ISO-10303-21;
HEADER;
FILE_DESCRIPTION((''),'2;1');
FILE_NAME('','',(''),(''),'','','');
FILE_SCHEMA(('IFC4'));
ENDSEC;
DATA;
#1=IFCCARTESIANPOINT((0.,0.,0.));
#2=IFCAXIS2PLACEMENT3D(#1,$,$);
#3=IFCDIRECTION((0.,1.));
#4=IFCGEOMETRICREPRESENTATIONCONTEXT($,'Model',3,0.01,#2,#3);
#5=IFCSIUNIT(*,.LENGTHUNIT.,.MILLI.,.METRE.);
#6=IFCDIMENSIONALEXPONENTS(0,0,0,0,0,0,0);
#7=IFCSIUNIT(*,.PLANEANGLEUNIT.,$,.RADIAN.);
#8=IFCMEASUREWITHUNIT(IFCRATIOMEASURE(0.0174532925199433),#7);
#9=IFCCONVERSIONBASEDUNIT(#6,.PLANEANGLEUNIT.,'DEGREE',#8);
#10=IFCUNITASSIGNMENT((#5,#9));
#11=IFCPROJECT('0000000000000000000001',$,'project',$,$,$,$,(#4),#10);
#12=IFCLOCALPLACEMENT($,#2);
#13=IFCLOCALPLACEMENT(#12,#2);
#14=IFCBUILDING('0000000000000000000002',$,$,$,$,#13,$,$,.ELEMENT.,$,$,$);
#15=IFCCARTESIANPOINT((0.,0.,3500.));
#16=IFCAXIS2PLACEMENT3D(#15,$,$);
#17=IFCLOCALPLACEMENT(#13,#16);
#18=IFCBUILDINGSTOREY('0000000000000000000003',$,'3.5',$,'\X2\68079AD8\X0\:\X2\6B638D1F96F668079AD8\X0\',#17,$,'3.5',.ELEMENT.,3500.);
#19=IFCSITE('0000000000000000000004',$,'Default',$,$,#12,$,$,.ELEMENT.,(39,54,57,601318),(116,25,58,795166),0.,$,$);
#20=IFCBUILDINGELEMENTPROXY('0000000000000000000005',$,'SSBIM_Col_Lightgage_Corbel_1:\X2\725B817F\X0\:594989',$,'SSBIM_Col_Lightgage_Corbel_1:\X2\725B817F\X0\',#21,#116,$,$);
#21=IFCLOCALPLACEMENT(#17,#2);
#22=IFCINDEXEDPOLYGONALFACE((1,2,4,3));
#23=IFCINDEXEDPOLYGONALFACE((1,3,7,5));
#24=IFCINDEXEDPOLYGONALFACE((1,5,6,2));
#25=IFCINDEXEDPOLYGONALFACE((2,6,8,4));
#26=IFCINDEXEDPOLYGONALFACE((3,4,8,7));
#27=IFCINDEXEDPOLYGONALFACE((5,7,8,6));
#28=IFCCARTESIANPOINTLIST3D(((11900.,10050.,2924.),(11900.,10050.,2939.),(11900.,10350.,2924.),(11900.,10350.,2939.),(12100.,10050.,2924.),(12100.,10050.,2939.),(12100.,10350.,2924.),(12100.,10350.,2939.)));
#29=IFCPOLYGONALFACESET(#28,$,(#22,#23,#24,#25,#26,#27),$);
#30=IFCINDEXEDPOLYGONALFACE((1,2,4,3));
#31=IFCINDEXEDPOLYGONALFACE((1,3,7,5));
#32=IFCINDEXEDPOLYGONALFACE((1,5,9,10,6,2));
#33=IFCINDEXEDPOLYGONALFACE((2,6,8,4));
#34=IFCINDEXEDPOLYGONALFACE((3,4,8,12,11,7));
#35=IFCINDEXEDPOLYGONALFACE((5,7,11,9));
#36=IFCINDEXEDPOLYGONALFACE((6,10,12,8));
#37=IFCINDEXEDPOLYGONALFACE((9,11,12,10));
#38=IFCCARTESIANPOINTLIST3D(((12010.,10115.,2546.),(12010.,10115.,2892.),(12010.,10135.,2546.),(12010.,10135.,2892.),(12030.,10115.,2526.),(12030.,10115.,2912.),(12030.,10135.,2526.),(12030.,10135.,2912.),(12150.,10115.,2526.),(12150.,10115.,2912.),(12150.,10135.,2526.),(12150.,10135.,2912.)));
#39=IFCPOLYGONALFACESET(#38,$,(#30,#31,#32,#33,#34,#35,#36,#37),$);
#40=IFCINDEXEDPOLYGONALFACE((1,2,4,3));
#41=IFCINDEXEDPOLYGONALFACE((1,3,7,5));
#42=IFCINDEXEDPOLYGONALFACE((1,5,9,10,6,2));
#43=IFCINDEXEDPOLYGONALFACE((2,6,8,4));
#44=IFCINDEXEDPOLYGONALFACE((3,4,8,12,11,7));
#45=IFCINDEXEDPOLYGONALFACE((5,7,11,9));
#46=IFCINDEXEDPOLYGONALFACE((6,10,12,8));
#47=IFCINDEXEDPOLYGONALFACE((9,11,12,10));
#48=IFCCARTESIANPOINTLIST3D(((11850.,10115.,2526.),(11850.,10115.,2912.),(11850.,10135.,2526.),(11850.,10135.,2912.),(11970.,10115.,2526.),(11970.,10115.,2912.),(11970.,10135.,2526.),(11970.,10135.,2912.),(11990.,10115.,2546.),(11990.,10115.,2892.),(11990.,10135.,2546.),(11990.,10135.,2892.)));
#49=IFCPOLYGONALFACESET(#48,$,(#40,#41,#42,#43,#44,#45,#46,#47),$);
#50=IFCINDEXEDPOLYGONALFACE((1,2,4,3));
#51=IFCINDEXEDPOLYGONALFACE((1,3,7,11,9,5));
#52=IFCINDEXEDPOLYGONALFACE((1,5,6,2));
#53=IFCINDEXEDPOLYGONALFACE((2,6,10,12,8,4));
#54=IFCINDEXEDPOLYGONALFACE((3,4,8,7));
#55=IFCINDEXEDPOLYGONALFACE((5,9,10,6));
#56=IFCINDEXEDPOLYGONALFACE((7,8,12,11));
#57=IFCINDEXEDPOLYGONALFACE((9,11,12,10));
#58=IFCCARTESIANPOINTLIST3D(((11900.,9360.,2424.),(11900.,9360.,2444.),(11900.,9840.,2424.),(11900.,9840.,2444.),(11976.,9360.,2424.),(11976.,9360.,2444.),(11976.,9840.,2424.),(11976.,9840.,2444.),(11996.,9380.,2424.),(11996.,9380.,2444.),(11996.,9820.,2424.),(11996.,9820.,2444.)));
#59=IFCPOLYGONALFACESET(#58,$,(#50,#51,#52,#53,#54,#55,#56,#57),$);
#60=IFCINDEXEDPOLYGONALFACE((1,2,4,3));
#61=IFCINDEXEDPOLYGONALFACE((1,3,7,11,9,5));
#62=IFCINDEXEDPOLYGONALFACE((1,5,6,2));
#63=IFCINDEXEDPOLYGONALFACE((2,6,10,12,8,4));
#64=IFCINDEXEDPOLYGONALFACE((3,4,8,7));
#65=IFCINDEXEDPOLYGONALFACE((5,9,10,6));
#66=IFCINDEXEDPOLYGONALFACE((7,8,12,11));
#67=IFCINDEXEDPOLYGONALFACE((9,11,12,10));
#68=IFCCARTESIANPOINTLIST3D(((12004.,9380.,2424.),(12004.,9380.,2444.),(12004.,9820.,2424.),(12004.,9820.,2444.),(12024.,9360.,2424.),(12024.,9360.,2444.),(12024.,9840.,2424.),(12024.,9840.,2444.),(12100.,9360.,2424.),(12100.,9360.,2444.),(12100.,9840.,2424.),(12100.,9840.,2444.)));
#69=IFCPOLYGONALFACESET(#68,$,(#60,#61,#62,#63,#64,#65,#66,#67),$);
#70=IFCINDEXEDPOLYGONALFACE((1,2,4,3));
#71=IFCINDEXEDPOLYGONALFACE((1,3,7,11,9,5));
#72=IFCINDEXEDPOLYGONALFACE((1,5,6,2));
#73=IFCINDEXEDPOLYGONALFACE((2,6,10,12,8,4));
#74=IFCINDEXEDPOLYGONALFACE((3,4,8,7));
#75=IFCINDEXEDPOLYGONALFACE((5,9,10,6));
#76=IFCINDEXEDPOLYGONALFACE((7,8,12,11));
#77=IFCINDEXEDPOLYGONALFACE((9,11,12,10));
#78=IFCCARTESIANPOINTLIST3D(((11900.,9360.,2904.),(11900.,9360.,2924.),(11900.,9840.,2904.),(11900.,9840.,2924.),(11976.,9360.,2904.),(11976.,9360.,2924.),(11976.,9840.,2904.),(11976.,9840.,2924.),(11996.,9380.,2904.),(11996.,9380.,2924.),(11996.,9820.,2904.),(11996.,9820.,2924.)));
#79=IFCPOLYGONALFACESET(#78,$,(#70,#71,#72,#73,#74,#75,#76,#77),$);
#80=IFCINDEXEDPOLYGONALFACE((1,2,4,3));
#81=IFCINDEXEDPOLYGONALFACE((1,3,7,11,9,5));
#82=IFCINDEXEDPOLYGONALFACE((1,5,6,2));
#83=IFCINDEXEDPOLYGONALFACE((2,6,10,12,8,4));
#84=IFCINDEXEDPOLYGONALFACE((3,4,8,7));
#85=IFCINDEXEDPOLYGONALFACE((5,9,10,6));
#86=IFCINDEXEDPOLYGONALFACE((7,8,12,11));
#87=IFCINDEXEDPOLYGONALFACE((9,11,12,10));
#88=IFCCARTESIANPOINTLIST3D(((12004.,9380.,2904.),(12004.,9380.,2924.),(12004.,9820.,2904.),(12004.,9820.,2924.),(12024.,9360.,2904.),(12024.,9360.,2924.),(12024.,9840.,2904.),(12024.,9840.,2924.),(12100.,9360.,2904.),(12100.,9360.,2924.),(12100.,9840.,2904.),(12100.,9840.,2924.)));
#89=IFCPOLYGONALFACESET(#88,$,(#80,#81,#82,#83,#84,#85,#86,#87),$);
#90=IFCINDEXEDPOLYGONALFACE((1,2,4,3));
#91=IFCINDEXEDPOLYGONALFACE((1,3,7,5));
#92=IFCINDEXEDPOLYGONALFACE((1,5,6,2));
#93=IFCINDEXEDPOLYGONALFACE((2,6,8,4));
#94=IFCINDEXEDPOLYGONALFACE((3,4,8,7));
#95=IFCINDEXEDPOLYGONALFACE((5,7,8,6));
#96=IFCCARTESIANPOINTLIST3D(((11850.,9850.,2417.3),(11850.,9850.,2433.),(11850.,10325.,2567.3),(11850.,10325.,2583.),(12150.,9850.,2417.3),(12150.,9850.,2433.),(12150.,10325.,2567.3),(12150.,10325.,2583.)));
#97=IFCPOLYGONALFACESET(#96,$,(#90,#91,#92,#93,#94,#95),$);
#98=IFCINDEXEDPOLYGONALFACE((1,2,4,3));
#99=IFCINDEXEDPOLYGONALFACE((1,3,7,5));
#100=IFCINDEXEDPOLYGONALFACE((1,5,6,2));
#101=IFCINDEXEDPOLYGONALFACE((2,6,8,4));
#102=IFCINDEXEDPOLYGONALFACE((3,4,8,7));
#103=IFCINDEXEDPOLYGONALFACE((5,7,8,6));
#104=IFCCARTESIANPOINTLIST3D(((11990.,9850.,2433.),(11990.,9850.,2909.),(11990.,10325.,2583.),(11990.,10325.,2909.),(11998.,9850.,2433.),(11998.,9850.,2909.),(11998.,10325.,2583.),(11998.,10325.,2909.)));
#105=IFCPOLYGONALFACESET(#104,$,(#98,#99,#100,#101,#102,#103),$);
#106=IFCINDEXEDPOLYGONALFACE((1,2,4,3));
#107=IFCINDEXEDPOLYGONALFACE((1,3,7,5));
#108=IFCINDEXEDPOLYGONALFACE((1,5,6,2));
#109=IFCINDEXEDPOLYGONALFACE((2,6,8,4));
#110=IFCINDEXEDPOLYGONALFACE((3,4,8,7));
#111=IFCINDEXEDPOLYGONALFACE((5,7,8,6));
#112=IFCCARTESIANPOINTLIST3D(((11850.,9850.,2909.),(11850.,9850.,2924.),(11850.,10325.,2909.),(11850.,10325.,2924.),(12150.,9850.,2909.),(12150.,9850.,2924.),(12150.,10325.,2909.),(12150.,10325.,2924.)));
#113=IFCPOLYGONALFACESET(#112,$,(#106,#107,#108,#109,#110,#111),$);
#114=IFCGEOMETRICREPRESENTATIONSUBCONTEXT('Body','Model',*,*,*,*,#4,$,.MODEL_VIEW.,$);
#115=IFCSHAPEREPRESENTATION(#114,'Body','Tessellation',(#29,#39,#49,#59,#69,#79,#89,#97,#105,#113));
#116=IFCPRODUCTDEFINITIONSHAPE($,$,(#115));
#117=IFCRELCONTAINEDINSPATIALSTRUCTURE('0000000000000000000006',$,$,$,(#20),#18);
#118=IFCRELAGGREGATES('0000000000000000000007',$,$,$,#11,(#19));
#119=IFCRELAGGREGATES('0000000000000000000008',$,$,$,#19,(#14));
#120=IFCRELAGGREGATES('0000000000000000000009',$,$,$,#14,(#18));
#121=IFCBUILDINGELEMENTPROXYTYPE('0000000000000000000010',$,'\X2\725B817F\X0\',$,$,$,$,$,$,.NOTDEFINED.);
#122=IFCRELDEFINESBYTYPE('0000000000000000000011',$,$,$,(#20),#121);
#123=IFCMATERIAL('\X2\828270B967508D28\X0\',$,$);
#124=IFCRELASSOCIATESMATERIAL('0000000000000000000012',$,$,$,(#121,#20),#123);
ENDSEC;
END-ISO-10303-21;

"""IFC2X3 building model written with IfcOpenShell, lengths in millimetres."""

from ifc_helpers import new_model, entity, si_unit, converted_unit, direction, frame, frame_2d, origin, origin_2d_with_axis, place, context, subcontext, project, spatial, polyline, rectangle, outline, extrude, source, transform, mapped, material, type_object, type_shapes, element, save


model = new_model("IFC2X3")

# Units and contexts
model_context = context("Model", 3, precision=0.01, world=origin(), true_north=direction((0.0, 1.0)))
body_context = subcontext(model_context, "Body", "Model", "MODEL_VIEW")
ifc_project = project(units=[si_unit("LENGTHUNIT", "METRE", prefix="MILLI"), converted_unit("PLANEANGLEUNIT", "DEGREE", entity("IfcRatioMeasure", 0.0174532925199433), si_unit("PLANEANGLEUNIT", "RADIAN"), dimensions=[0, 0, 0, 0, 0, 0, 0])], contexts=[model_context])

# Site, building, storey
site_placement = place(None, origin())
site = spatial("IfcSite", under=ifc_project, at=site_placement, Name="Default", CompositionType="ELEMENT", RefLatitude=(39, 54, 57, 601318), RefLongitude=(116, 25, 58, 795166), RefElevation=0.0)
building_placement = place(site_placement, origin())
building = spatial("IfcBuilding", under=site, at=building_placement, CompositionType="ELEMENT")
storey_placement = place(building_placement, frame((0.0, 0.0, 3500.0)))
storey = spatial("IfcBuildingStorey", under=building, at=storey_placement, Name="3.5", ObjectType="标高:正负零标高", LongName="3.5", CompositionType="ELEMENT", Elevation=3500.0)

# Building element proxy
ifc_material_1 = material(Name="节点材质")
building_element_proxy_type_1 = type_object("IfcBuildingElementProxyType", Name="牛腿", PredefinedType="NOTDEFINED", material=ifc_material_1)
shared_shape_1 = source(origin(), body_context, "Body", "SweptSolid", [
    extrude(rectangle(XDim=200.0, YDim=300.0, at=frame_2d((0.0, 0.0), x_axis=(1.0, 0.0))), frame((636.4, 0.0, 0.0), z_axis=(0.0, 0.0, 1.0), x_axis=(0.0, -1.0, 0.0)), (0.0, 0.0, 1.0), 15.0),
    extrude(outline(polyline([(-86.7, -193.0), (33.3, -193.0), (53.3, -173.0), (53.3, 173.0), (33.3, 193.0), (-86.7, 193.0), (-86.7, -193.0)])), frame((551.4, -63.3, -205.0), z_axis=(1.0, 0.0, 0.0), x_axis=(0.0, 1.0, 0.0)), (0.0, 0.0, 1.0), 20.0),
    extrude(outline(polyline([(-193.0, -86.7), (193.0, -86.7), (193.0, 33.3), (173.0, 53.3), (-173.0, 53.3), (-193.0, 33.3), (-193.0, -86.7)])), frame((551.4, 63.3, -205.0), z_axis=(1.0, 0.0, 0.0), x_axis=(0.0, 0.0, 1.0)), (0.0, 0.0, 1.0), 20.0),
    extrude(outline(polyline([(-57.3, -240.0), (18.7, -240.0), (38.7, -220.0), (38.7, 220.0), (18.7, 240.0), (-57.3, 240.0), (-57.3, -240.0)])), frame((36.4, 42.7, -500.0), z_axis=(0.0, 0.0, 1.0), x_axis=(0.0, -1.0, 0.0)), (0.0, 0.0, 1.0), 20.0),
    extrude(outline(polyline([(-240.0, -57.3), (240.0, -57.3), (240.0, 18.7), (220.0, 38.7), (-220.0, 38.7), (-240.0, 18.7), (-240.0, -57.3)])), frame((36.4, -42.7, -500.0)), (0.0, 0.0, 1.0), 20.0),
    extrude(outline(polyline([(-57.3, -240.0), (18.7, -240.0), (38.7, -220.0), (38.7, 220.0), (18.7, 240.0), (-57.3, 240.0), (-57.3, -240.0)])), frame((36.4, 42.7, -20.0), z_axis=(0.0, 0.0, 1.0), x_axis=(0.0, -1.0, 0.0)), (0.0, 0.0, 1.0), 20.0),
    extrude(outline(polyline([(-240.0, -57.3), (240.0, -57.3), (240.0, 18.7), (220.0, 38.7), (-220.0, 38.7), (-240.0, 18.7), (-240.0, -57.3)])), frame((36.4, -42.7, -20.0)), (0.0, 0.0, 1.0), 20.0),
    extrude(outline(polyline([(-82.9, -237.5), (-67.1, -237.5), (82.9, 237.5), (67.1, 237.5), (-82.9, -237.5)])), frame((523.9, -150.0, -423.9), z_axis=(0.0, 1.0, 0.0), x_axis=(0.0, 0.0, 1.0)), (0.0, 0.0, 1.0), 300.0),
    extrude(outline(polyline([(-237.5, -200.5), (237.5, -200.5), (237.5, 125.5), (-237.5, 275.5), (-237.5, -200.5)])), frame((523.9, 2.0, -215.5), z_axis=(0.0, 1.0, 0.0), x_axis=(1.0, 0.0, 0.0)), (0.0, 0.0, 1.0), 8.0),
    extrude(rectangle(XDim=300.0, YDim=475.0, at=origin_2d_with_axis()), frame((523.9, 0.0, -15.0), z_axis=(0.0, 0.0, 1.0), x_axis=(0.0, -1.0, 0.0)), (0.0, 0.0, 1.0), 15.0),
])
type_shapes(building_element_proxy_type_1, [shared_shape_1])
for number, where, z_axis, x_axis, name in (
    (1, (12000.0, 9563.6, 2924.0), (0.0, 0.0, 1.0), (0.0, 1.0, 0.0), "SSBIM_Col_Lightgage_Corbel_1:牛腿:594989"),
):
    element("IfcBuildingElementProxy", number, at=place(storey_placement, frame(where, z_axis=z_axis, x_axis=x_axis)), inside=storey, type_object=building_element_proxy_type_1, material=ifc_material_1, Name=name, ObjectType="SSBIM_Col_Lightgage_Corbel_1:牛腿", context=body_context, shape_type="MappedRepresentation", body=[
        mapped(shared_shape_1, transform((0.0, 0.0, 0.0), scale=1.0)),
    ])

save(model, "model.ifc")
